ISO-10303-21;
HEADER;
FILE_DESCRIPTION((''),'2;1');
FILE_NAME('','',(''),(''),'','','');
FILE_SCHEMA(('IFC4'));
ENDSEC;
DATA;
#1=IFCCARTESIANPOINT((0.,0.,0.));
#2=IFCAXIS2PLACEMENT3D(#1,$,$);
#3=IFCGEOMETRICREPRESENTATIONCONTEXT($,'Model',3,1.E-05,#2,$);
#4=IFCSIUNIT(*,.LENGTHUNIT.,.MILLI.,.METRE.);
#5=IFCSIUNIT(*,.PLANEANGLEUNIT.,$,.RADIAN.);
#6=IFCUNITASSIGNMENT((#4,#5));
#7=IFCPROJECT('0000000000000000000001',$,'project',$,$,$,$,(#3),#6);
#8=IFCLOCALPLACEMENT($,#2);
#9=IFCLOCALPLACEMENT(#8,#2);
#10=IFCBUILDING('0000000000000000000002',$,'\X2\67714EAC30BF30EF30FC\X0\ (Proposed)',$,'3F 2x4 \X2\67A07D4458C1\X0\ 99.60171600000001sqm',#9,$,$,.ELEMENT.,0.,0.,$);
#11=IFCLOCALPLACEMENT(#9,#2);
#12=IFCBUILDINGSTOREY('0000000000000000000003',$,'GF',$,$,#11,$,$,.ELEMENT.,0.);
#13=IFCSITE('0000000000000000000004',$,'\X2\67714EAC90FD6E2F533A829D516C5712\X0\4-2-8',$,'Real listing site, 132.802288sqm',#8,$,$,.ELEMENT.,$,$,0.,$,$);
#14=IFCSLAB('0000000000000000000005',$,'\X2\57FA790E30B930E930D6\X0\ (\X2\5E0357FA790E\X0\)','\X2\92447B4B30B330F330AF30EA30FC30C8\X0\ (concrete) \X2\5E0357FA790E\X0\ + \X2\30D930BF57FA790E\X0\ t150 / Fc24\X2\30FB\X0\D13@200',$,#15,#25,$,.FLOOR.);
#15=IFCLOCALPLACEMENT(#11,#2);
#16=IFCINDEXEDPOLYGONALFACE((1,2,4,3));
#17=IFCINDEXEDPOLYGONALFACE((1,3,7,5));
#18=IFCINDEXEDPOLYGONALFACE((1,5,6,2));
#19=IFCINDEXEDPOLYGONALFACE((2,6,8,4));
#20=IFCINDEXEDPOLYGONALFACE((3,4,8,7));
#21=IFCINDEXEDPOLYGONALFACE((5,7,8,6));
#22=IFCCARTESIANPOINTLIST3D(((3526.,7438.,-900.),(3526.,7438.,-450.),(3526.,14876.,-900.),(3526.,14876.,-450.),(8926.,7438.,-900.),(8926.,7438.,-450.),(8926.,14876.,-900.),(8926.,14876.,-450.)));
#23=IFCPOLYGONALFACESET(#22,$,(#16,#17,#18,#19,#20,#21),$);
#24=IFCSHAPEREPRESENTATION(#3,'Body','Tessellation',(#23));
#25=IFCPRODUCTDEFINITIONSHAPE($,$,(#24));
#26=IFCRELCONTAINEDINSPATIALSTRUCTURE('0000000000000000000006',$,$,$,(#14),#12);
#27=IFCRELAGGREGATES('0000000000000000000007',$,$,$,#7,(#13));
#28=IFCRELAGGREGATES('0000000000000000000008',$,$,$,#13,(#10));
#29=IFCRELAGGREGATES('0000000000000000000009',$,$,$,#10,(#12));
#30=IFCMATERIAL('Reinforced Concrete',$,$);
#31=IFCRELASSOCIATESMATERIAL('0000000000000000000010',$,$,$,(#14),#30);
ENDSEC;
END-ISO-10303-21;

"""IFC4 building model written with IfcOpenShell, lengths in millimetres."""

from ifc_helpers import new_model, si_unit, frame, frame_2d, origin, place, context, project, spatial, rectangle, extrude, material, element, save


model = new_model("IFC4")

# Units and contexts
model_context = context("Model", 3, precision=1e-05, world=origin())
ifc_project = project(units=[si_unit("LENGTHUNIT", "METRE", prefix="MILLI"), si_unit("PLANEANGLEUNIT", "RADIAN")], contexts=[model_context])

# Site, building, storey
site_placement = place(None, origin())
site = spatial("IfcSite", under=ifc_project, at=site_placement, Name="東京都港区芝公園4-2-8", ObjectType="Real listing site, 132.802288sqm", CompositionType="ELEMENT", RefElevation=0.0)
building_placement = place(site_placement, origin())
building = spatial("IfcBuilding", under=site, at=building_placement, Name="東京タワー (Proposed)", ObjectType="3F 2x4 枠組壁 99.60171600000001sqm", CompositionType="ELEMENT", ElevationOfRefHeight=0.0, ElevationOfTerrain=0.0)
storey_placement = place(building_placement, origin())
storey = spatial("IfcBuildingStorey", under=building, at=storey_placement, Name="GF", CompositionType="ELEMENT", Elevation=0.0)

# Slab
ifc_material_1 = material(Name="Reinforced Concrete")
slab_1_placement = place(storey_placement, frame((1763.0, 3719.0, -450.0)))
element("IfcSlab", 1, at=slab_1_placement, inside=storey, material=ifc_material_1, Name="基礎スラブ (布基礎)", Description="鉄筋コンクリート (concrete) 布基礎 + ベタ基礎 t150 / Fc24・D13@200", PredefinedType="FLOOR", context=model_context, shape_type="SweptSolid", body=[
    extrude(rectangle(XDim=5400.0, YDim=7438.0, at=frame_2d((2700.0, 3719.0))), frame((1763.0, 3719.0, -450.0)), (0.0, 0.0, 1.0), 450.0),
])

save(model, "model.ifc")
